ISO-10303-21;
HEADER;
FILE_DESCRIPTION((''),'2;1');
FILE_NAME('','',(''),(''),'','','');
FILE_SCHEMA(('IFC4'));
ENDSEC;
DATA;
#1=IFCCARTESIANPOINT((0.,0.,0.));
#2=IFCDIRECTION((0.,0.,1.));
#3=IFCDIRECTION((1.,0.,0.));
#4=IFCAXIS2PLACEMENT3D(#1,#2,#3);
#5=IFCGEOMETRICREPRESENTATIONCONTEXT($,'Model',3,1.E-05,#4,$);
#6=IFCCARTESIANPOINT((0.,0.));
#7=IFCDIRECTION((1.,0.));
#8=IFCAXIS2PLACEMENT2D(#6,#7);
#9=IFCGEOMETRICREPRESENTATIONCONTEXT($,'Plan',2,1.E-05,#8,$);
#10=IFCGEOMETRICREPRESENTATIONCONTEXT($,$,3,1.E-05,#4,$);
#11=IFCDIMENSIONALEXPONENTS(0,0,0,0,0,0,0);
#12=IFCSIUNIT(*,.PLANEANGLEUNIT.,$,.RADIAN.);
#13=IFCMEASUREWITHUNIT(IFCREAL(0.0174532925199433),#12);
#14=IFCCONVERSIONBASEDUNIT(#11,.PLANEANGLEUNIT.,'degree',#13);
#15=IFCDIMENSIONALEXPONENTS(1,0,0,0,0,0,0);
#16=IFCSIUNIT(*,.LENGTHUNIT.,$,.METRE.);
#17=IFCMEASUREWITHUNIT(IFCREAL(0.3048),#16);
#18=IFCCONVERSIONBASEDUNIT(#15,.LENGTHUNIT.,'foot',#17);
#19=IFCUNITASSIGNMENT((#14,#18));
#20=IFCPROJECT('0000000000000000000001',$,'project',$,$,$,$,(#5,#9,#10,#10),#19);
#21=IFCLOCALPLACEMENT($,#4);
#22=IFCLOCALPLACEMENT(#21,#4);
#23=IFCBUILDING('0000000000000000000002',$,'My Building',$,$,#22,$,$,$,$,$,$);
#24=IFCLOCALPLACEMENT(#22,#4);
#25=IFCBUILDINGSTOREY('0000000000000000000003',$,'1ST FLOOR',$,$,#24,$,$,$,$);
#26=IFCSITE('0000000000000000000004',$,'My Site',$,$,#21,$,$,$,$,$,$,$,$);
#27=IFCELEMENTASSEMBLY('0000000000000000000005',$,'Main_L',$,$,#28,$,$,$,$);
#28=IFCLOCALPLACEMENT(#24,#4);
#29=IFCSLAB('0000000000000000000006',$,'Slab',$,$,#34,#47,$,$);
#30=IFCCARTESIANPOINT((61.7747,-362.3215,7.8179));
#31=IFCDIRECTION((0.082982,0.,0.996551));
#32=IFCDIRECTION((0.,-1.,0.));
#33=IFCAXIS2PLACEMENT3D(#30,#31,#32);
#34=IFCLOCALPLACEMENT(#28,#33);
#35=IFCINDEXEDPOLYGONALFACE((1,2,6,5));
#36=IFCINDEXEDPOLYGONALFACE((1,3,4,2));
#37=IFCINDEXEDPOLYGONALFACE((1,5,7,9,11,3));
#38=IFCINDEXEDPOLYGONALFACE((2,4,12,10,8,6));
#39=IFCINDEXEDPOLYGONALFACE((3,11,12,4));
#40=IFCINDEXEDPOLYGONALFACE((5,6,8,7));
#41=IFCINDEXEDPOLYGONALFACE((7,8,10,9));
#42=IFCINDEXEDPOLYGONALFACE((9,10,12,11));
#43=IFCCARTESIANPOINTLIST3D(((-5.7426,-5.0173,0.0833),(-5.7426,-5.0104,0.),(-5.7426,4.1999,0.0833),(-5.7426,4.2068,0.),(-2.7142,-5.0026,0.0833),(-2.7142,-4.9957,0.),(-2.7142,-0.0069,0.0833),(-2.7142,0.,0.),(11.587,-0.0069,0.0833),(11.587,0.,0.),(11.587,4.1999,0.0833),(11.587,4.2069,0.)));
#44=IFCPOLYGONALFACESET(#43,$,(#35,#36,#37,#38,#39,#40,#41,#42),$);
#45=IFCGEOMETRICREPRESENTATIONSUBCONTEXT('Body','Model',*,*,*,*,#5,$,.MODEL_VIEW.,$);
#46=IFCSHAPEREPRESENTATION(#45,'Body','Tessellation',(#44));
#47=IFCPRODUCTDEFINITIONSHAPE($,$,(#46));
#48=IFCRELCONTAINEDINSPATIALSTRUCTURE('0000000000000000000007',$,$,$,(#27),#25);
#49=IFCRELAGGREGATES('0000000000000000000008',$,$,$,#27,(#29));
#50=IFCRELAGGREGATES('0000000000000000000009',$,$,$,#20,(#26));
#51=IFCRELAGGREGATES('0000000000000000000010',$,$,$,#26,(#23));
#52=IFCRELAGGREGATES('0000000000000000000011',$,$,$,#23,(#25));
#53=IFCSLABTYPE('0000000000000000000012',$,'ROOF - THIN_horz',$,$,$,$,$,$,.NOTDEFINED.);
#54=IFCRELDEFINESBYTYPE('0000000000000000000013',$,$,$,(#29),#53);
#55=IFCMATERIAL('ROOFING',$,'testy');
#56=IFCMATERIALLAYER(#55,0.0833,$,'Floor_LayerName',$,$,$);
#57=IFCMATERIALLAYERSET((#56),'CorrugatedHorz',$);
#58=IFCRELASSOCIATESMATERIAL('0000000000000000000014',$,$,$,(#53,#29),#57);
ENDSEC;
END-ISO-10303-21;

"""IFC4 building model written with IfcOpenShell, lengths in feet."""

from ifc_helpers import new_model, entity, si_unit, converted_unit, frame, origin_with_axes, origin_2d_with_axis, place, context, subcontext, project, spatial, line, indexed_curve, outline, extrude, material, layer, layer_set, layer_usage, type_object, element, aggregate, save


model = new_model("IFC4")

# Units and contexts
model_context = context("Model", 3, precision=1e-05, world=origin_with_axes())
plan_context = context("Plan", 2, precision=1e-05, world=origin_2d_with_axis())
context_of_model = context(None, 3, precision=1e-05, world=origin_with_axes())
body_context = subcontext(model_context, "Body", "Model", "MODEL_VIEW")
ifc_project = project(units=[converted_unit("PLANEANGLEUNIT", "degree", entity("IfcReal", 0.0174532925199433), si_unit("PLANEANGLEUNIT", "RADIAN"), dimensions=[0, 0, 0, 0, 0, 0, 0]), converted_unit("LENGTHUNIT", "foot", entity("IfcReal", 0.3048), si_unit("LENGTHUNIT", "METRE"), dimensions=[1, 0, 0, 0, 0, 0, 0])], contexts=[model_context, plan_context, context_of_model, context_of_model])

# Site, building, storey
site_placement = place(None, origin_with_axes())
site = spatial("IfcSite", under=ifc_project, at=site_placement, Name="My Site")
building_placement = place(site_placement, origin_with_axes())
building = spatial("IfcBuilding", under=site, at=building_placement, Name="My Building")
storey_placement = place(building_placement, origin_with_axes())
storey = spatial("IfcBuildingStorey", under=building, at=storey_placement, Name="1ST FLOOR")

# Element assembly
assembly_1_placement = place(storey_placement, origin_with_axes())
assembly_1 = element("IfcElementAssembly", 1, at=assembly_1_placement, inside=storey, Name="Main_L")

# Slab
ifc_material_1 = material(Name="ROOFING", Category="testy")
ifc_layer_1 = layer(ifc_material_1, 0.0833, Name="Floor_LayerName")
ifc_layer_set_1 = layer_set([ifc_layer_1], Name="CorrugatedHorz")
ifc_layer_usage_1 = layer_usage(ifc_layer_set_1, "AXIS3", "POSITIVE", 0.0)
slab_type_1 = type_object("IfcSlabType", Name="ROOF - THIN_horz", PredefinedType="NOTDEFINED", material=ifc_layer_set_1)
slab_1_placement = place(assembly_1_placement, frame((61.7747, -362.3215, 7.8179), z_axis=(0.082982, 0.0, 0.996551), x_axis=(0.0, -1.0, 0.0)))
slab_1 = element("IfcSlab", 2, at=slab_1_placement, type_object=slab_type_1, material=ifc_layer_usage_1, Name="Slab", context=body_context, shape_type="SweptSolid", body=[
    extrude(outline(indexed_curve([(11.587, 0.0), (11.587, 4.2069), (-5.7426, 4.2068), (-5.7426, -5.0104), (-2.7142, -4.9957), (-2.7142, 0.0)], segments=[line(2, 1), line(1, 6), line(6, 5), line(5, 4), line(4, 3), line(3, 2)], self_intersect=False)), None, (0.0, -0.082982, 0.996551), 0.0836),
])

aggregate(assembly_1, [slab_1])

save(model, "model.ifc")
